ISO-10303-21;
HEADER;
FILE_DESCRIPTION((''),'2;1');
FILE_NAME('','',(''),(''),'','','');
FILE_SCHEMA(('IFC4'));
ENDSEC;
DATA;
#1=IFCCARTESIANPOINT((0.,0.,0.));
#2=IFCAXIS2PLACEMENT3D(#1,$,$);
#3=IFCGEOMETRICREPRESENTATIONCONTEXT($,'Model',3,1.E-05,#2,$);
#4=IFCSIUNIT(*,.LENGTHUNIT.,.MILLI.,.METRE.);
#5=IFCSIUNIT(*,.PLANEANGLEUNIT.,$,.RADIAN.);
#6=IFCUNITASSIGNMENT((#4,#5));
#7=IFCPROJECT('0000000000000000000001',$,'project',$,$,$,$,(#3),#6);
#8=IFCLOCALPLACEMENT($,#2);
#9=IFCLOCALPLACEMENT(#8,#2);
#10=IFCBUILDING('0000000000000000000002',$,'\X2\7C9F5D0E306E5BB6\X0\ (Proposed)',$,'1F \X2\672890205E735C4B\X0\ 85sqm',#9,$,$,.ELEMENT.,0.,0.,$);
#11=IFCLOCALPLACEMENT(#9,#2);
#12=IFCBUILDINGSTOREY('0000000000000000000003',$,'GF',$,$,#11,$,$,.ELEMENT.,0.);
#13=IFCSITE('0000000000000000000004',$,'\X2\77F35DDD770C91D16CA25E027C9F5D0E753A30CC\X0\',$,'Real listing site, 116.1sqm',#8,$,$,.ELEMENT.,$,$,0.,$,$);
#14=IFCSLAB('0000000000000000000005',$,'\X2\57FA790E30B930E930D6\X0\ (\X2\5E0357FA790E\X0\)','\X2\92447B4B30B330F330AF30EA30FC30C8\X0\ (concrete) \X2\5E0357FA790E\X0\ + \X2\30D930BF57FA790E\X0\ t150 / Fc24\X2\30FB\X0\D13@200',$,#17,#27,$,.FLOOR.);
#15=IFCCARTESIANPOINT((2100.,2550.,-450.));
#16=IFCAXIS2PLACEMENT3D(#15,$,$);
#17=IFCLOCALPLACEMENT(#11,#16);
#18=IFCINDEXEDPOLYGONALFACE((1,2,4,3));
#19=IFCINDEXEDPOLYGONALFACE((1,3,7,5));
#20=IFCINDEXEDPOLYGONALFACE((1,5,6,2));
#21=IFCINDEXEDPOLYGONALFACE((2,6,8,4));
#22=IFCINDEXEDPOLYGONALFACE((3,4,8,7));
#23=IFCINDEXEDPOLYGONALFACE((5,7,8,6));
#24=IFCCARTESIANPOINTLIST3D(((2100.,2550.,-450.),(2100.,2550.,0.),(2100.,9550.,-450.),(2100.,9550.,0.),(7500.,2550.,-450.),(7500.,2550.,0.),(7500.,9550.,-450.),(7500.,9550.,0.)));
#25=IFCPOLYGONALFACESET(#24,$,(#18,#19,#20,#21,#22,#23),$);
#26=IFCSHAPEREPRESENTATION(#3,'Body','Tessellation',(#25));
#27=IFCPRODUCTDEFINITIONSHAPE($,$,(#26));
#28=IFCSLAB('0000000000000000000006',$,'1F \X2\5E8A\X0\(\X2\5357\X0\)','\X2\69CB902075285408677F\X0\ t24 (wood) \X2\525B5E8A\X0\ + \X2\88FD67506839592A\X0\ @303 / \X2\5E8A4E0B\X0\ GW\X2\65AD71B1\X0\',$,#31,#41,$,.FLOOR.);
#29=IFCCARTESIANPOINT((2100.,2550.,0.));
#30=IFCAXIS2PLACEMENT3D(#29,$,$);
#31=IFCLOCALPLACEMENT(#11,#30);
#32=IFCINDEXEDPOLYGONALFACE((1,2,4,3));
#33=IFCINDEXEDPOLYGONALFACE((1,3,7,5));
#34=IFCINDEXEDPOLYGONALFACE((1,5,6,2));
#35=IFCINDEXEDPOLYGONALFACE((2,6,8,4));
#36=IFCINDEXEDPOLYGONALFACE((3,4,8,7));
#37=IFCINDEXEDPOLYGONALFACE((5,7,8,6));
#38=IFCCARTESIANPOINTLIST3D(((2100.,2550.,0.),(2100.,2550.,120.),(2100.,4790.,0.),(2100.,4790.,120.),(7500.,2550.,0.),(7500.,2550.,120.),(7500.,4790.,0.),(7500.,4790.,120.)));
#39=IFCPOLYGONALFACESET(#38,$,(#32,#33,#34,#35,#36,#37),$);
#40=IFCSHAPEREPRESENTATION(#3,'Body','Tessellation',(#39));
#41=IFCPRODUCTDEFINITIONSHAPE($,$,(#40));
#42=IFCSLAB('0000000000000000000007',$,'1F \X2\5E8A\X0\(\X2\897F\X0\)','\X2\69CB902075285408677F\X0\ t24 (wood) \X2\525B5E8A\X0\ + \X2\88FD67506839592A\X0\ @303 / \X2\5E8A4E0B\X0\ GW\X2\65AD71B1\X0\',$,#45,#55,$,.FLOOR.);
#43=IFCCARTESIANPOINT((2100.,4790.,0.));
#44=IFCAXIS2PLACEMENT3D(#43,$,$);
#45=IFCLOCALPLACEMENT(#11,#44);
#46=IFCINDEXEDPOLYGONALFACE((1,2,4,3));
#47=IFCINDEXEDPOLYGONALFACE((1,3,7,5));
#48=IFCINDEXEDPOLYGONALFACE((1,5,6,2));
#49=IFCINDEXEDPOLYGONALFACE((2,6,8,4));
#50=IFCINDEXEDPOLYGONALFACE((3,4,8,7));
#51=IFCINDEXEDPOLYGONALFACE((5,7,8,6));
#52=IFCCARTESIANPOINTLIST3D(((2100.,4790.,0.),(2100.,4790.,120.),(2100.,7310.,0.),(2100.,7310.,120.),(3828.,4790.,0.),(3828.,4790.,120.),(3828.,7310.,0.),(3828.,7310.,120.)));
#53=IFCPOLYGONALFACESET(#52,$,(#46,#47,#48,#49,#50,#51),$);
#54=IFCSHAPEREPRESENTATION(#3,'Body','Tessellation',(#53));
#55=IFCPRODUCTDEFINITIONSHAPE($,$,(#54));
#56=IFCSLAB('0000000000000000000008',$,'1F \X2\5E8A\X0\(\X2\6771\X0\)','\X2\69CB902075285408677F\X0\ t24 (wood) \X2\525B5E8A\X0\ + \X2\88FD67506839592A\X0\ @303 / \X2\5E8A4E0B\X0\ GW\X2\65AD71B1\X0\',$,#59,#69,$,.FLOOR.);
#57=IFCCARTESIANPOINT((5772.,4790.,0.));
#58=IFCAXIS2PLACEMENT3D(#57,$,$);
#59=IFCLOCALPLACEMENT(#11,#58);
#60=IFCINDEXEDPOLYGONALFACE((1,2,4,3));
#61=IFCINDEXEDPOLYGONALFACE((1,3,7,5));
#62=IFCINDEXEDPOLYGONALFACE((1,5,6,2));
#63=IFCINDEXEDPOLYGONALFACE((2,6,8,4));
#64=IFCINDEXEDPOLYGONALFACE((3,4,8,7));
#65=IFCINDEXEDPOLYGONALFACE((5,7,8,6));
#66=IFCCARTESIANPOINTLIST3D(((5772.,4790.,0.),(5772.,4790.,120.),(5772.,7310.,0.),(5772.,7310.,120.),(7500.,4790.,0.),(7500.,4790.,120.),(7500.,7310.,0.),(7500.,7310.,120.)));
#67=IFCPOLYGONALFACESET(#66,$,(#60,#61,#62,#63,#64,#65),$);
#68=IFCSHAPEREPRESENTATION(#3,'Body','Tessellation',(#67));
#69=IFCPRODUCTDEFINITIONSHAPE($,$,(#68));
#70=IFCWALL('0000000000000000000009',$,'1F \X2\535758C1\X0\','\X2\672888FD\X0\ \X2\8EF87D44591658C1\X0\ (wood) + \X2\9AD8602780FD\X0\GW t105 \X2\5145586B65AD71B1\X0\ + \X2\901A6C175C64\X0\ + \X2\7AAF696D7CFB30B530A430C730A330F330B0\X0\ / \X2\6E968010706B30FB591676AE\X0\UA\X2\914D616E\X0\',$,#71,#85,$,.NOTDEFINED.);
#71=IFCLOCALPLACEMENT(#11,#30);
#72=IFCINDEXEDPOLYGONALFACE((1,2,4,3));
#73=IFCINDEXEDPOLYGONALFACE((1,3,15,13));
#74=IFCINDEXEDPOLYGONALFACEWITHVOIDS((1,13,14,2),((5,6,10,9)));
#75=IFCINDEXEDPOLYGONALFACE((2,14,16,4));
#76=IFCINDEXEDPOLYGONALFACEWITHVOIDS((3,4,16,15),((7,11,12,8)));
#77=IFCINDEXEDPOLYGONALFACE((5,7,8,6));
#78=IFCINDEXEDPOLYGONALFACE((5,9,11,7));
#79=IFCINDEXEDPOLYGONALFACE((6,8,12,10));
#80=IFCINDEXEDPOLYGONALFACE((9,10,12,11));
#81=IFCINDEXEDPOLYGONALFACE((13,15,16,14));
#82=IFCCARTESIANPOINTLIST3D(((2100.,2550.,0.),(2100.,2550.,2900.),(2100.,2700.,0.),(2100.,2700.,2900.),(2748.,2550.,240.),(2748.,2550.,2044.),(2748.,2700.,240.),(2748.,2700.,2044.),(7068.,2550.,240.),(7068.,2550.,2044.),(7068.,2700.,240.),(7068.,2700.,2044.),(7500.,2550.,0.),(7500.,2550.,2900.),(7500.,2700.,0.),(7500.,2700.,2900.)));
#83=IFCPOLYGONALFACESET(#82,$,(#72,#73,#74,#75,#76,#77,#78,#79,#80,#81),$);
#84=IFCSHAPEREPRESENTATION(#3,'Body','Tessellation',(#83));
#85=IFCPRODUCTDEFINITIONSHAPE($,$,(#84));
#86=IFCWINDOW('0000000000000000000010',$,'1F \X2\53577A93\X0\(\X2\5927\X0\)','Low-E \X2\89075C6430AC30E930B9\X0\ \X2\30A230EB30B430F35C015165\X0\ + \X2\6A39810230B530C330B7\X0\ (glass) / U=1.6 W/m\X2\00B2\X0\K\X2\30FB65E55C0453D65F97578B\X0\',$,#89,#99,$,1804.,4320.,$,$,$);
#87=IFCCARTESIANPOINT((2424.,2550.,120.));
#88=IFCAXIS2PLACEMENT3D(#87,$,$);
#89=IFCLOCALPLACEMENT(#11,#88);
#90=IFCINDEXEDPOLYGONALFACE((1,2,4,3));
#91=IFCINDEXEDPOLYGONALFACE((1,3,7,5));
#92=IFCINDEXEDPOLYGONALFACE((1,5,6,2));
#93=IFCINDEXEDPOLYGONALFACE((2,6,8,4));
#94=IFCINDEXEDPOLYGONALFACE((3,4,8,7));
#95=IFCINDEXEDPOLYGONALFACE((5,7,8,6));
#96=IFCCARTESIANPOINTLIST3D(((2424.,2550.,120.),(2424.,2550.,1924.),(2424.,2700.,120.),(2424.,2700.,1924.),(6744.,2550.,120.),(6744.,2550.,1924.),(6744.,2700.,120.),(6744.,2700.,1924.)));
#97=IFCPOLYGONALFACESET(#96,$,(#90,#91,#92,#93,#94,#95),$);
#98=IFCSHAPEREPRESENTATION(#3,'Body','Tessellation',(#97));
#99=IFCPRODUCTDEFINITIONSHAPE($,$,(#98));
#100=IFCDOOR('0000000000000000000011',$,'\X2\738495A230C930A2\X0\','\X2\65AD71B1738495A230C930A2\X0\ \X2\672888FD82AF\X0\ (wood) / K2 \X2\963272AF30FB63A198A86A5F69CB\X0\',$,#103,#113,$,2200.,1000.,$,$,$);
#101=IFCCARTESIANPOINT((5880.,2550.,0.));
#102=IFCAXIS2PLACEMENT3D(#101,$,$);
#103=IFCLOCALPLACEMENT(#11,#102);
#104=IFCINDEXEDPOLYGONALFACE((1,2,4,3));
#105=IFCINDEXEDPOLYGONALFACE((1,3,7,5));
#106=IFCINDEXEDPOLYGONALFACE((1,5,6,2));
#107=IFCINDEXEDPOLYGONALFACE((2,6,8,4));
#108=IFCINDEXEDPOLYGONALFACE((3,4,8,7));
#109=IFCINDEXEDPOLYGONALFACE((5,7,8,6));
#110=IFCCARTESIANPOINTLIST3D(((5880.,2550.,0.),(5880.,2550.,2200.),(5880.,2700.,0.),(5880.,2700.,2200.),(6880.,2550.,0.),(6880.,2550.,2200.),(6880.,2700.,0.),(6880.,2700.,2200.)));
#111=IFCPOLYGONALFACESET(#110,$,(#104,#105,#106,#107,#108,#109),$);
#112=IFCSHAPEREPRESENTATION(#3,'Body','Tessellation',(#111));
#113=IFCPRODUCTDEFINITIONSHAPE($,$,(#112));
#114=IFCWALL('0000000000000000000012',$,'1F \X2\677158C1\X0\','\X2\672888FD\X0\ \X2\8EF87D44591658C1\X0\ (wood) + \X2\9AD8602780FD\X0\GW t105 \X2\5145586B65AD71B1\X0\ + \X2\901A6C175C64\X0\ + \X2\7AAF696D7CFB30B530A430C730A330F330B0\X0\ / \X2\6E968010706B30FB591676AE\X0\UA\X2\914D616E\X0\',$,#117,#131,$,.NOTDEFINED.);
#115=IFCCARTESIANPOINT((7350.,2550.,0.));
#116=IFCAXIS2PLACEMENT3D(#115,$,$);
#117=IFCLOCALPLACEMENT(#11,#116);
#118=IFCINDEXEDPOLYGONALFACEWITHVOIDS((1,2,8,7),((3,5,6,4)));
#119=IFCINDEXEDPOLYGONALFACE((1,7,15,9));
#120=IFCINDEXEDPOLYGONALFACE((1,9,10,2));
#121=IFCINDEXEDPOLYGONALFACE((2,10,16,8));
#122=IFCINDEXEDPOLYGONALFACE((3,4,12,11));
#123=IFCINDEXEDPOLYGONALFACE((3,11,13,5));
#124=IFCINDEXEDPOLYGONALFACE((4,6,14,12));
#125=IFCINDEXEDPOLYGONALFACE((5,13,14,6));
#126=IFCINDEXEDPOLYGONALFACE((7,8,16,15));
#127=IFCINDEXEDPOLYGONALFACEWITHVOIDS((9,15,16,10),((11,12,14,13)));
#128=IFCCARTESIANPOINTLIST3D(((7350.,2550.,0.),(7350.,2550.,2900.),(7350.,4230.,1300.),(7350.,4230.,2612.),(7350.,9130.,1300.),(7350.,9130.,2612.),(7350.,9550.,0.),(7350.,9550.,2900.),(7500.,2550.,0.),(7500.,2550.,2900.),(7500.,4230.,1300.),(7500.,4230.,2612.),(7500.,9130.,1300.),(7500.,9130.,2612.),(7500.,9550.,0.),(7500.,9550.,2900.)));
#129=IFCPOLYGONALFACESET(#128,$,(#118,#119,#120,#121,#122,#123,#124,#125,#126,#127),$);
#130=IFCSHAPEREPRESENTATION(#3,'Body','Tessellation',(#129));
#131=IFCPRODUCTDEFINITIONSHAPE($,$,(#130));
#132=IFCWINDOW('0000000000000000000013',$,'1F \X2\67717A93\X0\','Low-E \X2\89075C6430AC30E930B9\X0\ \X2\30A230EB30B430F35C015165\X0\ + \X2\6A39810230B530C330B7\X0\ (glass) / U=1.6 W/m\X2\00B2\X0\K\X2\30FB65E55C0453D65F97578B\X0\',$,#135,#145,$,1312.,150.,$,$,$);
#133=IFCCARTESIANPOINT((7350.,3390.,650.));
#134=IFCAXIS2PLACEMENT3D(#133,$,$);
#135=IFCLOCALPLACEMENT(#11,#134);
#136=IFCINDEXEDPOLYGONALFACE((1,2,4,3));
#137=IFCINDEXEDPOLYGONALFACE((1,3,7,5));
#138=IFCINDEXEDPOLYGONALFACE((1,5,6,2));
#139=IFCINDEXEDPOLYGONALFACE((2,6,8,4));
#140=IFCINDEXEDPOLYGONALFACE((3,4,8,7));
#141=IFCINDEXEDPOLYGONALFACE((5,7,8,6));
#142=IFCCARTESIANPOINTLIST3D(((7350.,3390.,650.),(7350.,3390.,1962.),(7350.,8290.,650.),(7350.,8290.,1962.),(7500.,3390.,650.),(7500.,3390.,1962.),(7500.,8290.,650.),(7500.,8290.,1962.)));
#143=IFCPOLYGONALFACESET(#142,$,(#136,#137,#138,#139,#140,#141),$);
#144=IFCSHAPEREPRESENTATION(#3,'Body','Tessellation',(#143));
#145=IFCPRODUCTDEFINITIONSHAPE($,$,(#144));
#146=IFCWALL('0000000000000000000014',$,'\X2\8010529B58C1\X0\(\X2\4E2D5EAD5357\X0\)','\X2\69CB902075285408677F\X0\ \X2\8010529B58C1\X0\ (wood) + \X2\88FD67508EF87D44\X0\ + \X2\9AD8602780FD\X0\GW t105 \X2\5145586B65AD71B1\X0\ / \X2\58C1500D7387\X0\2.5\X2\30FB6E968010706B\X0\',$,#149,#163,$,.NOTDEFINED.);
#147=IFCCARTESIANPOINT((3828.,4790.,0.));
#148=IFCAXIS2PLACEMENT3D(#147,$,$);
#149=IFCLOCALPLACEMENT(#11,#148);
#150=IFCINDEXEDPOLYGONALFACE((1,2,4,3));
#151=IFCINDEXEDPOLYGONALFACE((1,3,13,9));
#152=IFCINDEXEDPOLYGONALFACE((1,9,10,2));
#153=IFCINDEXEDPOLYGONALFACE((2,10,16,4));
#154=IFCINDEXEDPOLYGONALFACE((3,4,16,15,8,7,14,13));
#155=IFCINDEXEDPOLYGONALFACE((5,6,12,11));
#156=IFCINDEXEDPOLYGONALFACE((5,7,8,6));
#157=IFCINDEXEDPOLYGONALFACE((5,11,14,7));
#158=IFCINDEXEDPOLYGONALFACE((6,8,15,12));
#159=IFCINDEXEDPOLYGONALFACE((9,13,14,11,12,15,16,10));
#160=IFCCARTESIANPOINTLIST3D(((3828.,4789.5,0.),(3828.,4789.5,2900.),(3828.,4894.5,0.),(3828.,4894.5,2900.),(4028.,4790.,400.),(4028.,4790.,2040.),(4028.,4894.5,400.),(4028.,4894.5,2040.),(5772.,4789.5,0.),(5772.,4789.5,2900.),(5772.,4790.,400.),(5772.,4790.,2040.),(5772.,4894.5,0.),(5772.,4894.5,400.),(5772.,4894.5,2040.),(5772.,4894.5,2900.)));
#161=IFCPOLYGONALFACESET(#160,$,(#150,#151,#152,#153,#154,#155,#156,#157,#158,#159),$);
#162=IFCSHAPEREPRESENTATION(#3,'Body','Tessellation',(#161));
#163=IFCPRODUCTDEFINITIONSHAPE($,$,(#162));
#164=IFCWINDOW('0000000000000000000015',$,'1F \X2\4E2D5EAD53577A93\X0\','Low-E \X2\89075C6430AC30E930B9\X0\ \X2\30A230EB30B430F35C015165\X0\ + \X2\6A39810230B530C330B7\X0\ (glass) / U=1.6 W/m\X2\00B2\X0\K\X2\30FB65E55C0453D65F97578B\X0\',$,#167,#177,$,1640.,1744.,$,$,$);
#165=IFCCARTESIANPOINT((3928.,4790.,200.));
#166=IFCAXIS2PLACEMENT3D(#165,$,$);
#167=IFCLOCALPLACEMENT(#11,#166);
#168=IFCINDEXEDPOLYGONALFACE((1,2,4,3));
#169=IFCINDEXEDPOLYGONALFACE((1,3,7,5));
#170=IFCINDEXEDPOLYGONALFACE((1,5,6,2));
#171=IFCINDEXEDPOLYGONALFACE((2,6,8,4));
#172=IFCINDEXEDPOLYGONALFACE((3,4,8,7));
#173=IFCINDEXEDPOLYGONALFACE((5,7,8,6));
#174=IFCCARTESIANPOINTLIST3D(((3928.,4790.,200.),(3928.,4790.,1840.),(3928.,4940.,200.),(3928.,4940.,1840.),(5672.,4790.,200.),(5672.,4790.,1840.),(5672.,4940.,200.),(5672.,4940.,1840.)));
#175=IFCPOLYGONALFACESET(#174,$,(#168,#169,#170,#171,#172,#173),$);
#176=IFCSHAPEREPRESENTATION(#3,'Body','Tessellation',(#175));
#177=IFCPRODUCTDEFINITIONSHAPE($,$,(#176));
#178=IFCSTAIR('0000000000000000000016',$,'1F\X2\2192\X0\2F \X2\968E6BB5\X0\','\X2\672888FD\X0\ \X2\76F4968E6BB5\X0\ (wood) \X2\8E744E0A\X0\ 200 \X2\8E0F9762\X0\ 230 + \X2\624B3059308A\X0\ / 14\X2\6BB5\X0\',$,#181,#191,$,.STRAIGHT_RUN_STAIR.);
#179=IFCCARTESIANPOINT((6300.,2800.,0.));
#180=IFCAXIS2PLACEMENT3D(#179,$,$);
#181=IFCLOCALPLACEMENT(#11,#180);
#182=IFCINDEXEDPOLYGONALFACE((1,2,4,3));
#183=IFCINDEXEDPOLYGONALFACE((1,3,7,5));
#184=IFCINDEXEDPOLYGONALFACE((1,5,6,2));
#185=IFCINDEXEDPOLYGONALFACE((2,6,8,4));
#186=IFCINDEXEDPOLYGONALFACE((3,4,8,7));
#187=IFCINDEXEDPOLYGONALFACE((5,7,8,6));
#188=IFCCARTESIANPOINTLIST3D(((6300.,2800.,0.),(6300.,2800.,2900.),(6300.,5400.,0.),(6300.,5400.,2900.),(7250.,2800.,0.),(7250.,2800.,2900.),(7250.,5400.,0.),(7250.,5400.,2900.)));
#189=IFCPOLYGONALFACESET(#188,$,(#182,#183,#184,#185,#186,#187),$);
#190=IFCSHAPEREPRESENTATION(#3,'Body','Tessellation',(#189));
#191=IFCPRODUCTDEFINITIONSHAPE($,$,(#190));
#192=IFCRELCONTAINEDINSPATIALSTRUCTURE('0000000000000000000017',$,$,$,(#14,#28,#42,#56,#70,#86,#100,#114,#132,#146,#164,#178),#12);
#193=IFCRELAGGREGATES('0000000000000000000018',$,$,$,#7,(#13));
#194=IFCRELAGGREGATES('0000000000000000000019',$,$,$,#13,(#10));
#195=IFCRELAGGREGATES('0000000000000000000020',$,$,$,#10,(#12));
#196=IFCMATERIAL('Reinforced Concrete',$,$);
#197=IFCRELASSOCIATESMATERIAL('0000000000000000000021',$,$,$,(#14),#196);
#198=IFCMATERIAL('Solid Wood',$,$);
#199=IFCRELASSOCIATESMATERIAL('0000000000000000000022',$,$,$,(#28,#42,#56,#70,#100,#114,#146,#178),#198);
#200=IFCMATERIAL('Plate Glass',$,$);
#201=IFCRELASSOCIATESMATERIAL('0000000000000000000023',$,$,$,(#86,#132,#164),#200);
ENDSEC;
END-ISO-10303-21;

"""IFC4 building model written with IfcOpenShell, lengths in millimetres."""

from ifc_helpers import new_model, si_unit, frame, frame_2d, origin, place, context, project, spatial, rectangle, extrude, material, element, fill, save


model = new_model("IFC4")

# Units and contexts
model_context = context("Model", 3, precision=1e-05, world=origin())
ifc_project = project(units=[si_unit("LENGTHUNIT", "METRE", prefix="MILLI"), si_unit("PLANEANGLEUNIT", "RADIAN")], contexts=[model_context])

# Site, building, storey
site_placement = place(None, origin())
site = spatial("IfcSite", under=ifc_project, at=site_placement, Name="石川県金沢市粟崎町ヌ", ObjectType="Real listing site, 116.1sqm", CompositionType="ELEMENT", RefElevation=0.0)
building_placement = place(site_placement, origin())
building = spatial("IfcBuilding", under=site, at=building_placement, Name="粟崎の家 (Proposed)", ObjectType="1F 木造平屋 85sqm", CompositionType="ELEMENT", ElevationOfRefHeight=0.0, ElevationOfTerrain=0.0)
storey_placement = place(building_placement, origin())
storey = spatial("IfcBuildingStorey", under=building, at=storey_placement, Name="GF", CompositionType="ELEMENT", Elevation=0.0)

# Slabs
ifc_material_1 = material(Name="Reinforced Concrete")
slab_1_placement = place(storey_placement, frame((2100.0, 2550.0, -450.0)))
element("IfcSlab", 1, at=slab_1_placement, inside=storey, material=ifc_material_1, Name="基礎スラブ (布基礎)", Description="鉄筋コンクリート (concrete) 布基礎 + ベタ基礎 t150 / Fc24・D13@200", PredefinedType="FLOOR", context=model_context, shape_type="SweptSolid", body=[
    extrude(rectangle(XDim=5400.0, YDim=7000.0, at=frame_2d((2700.0, 3500.0))), frame((2100.0, 2550.0, -450.0)), (0.0, 0.0, 1.0), 450.0),
])
ifc_material_2 = material(Name="Solid Wood")
slab_2_placement = place(storey_placement, frame((2100.0, 2550.0, 0.0)))
element("IfcSlab", 2, at=slab_2_placement, inside=storey, material=ifc_material_2, Name="1F 床(南)", Description="構造用合板 t24 (wood) 剛床 + 製材根太 @303 / 床下 GW断熱", PredefinedType="FLOOR", context=model_context, shape_type="SweptSolid", body=[
    extrude(rectangle(XDim=5400.0, YDim=2240.0, at=frame_2d((2700.0, 1120.0))), frame((2100.0, 2550.0, 0.0)), (0.0, 0.0, 1.0), 120.0),
])
slab_3_placement = place(storey_placement, frame((2100.0, 4790.0, 0.0)))
element("IfcSlab", 3, at=slab_3_placement, inside=storey, material=ifc_material_2, Name="1F 床(西)", Description="構造用合板 t24 (wood) 剛床 + 製材根太 @303 / 床下 GW断熱", PredefinedType="FLOOR", context=model_context, shape_type="SweptSolid", body=[
    extrude(rectangle(XDim=1728.0, YDim=2520.0, at=frame_2d((864.0, 1260.0))), frame((2100.0, 4790.0, 0.0)), (0.0, 0.0, 1.0), 120.0),
])
slab_4_placement = place(storey_placement, frame((5772.0, 4790.0, 0.0)))
element("IfcSlab", 4, at=slab_4_placement, inside=storey, material=ifc_material_2, Name="1F 床(東)", Description="構造用合板 t24 (wood) 剛床 + 製材根太 @303 / 床下 GW断熱", PredefinedType="FLOOR", context=model_context, shape_type="SweptSolid", body=[
    extrude(rectangle(XDim=1728.0, YDim=2520.0, at=frame_2d((864.0, 1260.0))), frame((5772.0, 4790.0, 0.0)), (0.0, 0.0, 1.0), 120.0),
])

# Wall, openings, window, door
wall_1_placement = place(storey_placement, frame((2100.0, 2550.0, 0.0)))
wall_1 = element("IfcWall", 5, at=wall_1_placement, inside=storey, material=ifc_material_2, Name="1F 南壁", Description="木製 軸組外壁 (wood) + 高性能GW t105 充填断熱 + 通気層 + 窯業系サイディング / 準耐火・外皮UA配慮", PredefinedType="NOTDEFINED", context=model_context, shape_type="SweptSolid", body=[
    extrude(rectangle(XDim=5400.0, YDim=150.0, at=frame_2d((2700.0, 75.0))), frame((2100.0, 2550.0, 0.0)), (0.0, 0.0, 1.0), 2900.0),
])
opening_1_placement = place(storey_placement, frame((2424.0, 2550.0, 120.0)))
opening_1 = element("IfcOpeningElement", 6, at=opening_1_placement, cuts=wall_1, PredefinedType="NOTDEFINED", context=model_context, shape_type="SweptSolid", body=[
    extrude(rectangle(XDim=4320.0, YDim=150.0, at=frame_2d((2160.0, 75.0))), frame((2424.0, 2550.0, 120.0)), (0.0, 0.0, 1.0), 1804.0),
])
opening_2_placement = place(storey_placement, frame((5880.0, 2550.0, 0.0)))
opening_2 = element("IfcOpeningElement", 7, at=opening_2_placement, cuts=wall_1, PredefinedType="NOTDEFINED", context=model_context, shape_type="SweptSolid", body=[
    extrude(rectangle(XDim=1000.0, YDim=150.0, at=frame_2d((500.0, 75.0))), frame((5880.0, 2550.0, 0.0)), (0.0, 0.0, 1.0), 2200.0),
])
ifc_material_3 = material(Name="Plate Glass")
window_1_placement = place(storey_placement, frame((2424.0, 2550.0, 120.0)))
window_1 = element("IfcWindow", 8, at=window_1_placement, inside=storey, material=ifc_material_3, Name="1F 南窓(大)", Description="Low-E 複層ガラス アルゴン封入 + 樹脂サッシ (glass) / U=1.6 W/m²K・日射取得型", OverallHeight=1804.0, OverallWidth=4320.0, context=model_context, shape_type="SweptSolid", body=[
    extrude(rectangle(XDim=4320.0, YDim=150.0, at=frame_2d((2160.0, 75.0))), frame((2424.0, 2550.0, 120.0)), (0.0, 0.0, 1.0), 1804.0),
])
fill(opening_1, window_1)
door_placement = place(storey_placement, frame((5880.0, 2550.0, 0.0)))
door = element("IfcDoor", 9, at=door_placement, inside=storey, material=ifc_material_2, Name="玄関ドア", Description="断熱玄関ドア 木製芯 (wood) / K2 防犯・採風機構", OverallHeight=2200.0, OverallWidth=1000.0, context=model_context, shape_type="SweptSolid", body=[
    extrude(rectangle(XDim=1000.0, YDim=150.0, at=frame_2d((500.0, 75.0))), frame((5880.0, 2550.0, 0.0)), (0.0, 0.0, 1.0), 2200.0),
])
fill(opening_2, door)

# Walls, openings, windows
wall_2_placement = place(storey_placement, frame((7350.0, 2550.0, 0.0)))
wall_2 = element("IfcWall", 10, at=wall_2_placement, inside=storey, material=ifc_material_2, Name="1F 東壁", Description="木製 軸組外壁 (wood) + 高性能GW t105 充填断熱 + 通気層 + 窯業系サイディング / 準耐火・外皮UA配慮", PredefinedType="NOTDEFINED", context=model_context, shape_type="SweptSolid", body=[
    extrude(rectangle(XDim=150.0, YDim=7000.0, at=frame_2d((75.0, 3500.0))), frame((7350.0, 2550.0, 0.0)), (0.0, 0.0, 1.0), 2900.0),
])
opening_3_placement = place(storey_placement, frame((7350.0, 3390.0, 650.0)))
opening_3 = element("IfcOpeningElement", 11, at=opening_3_placement, cuts=wall_2, PredefinedType="NOTDEFINED", context=model_context, shape_type="SweptSolid", body=[
    extrude(rectangle(XDim=150.0, YDim=4900.0, at=frame_2d((75.0, 2450.0))), frame((7350.0, 3390.0, 650.0)), (0.0, 0.0, 1.0), 1312.0),
])
window_2_placement = place(storey_placement, frame((7350.0, 3390.0, 650.0)))
window_2 = element("IfcWindow", 12, at=window_2_placement, inside=storey, material=ifc_material_3, Name="1F 東窓", Description="Low-E 複層ガラス アルゴン封入 + 樹脂サッシ (glass) / U=1.6 W/m²K・日射取得型", OverallHeight=1312.0, OverallWidth=150.0, context=model_context, shape_type="SweptSolid", body=[
    extrude(rectangle(XDim=150.0, YDim=4900.0, at=frame_2d((75.0, 2450.0))), frame((7350.0, 3390.0, 650.0)), (0.0, 0.0, 1.0), 1312.0),
])
fill(opening_3, window_2)
wall_3_placement = place(storey_placement, frame((3828.0, 4790.0, 0.0)))
wall_3 = element("IfcWall", 13, at=wall_3_placement, inside=storey, material=ifc_material_2, Name="耐力壁(中庭南)", Description="構造用合板 耐力壁 (wood) + 製材軸組 + 高性能GW t105 充填断熱 / 壁倍率2.5・準耐火", PredefinedType="NOTDEFINED", context=model_context, shape_type="SweptSolid", body=[
    extrude(rectangle(XDim=1944.0, YDim=105.0, at=frame_2d((972.0, 52.0))), frame((3828.0, 4790.0, 0.0)), (0.0, 0.0, 1.0), 2900.0),
])
opening_4_placement = place(storey_placement, frame((3928.0, 4790.0, 200.0)))
opening_4 = element("IfcOpeningElement", 14, at=opening_4_placement, cuts=wall_3, PredefinedType="NOTDEFINED", context=model_context, shape_type="SweptSolid", body=[
    extrude(rectangle(XDim=1744.0, YDim=150.0, at=frame_2d((872.0, 75.0))), frame((3928.0, 4790.0, 200.0)), (0.0, 0.0, 1.0), 1640.0),
])
window_3_placement = place(storey_placement, frame((3928.0, 4790.0, 200.0)))
window_3 = element("IfcWindow", 15, at=window_3_placement, inside=storey, material=ifc_material_3, Name="1F 中庭南窓", Description="Low-E 複層ガラス アルゴン封入 + 樹脂サッシ (glass) / U=1.6 W/m²K・日射取得型", OverallHeight=1640.0, OverallWidth=1744.0, context=model_context, shape_type="SweptSolid", body=[
    extrude(rectangle(XDim=1744.0, YDim=150.0, at=frame_2d((872.0, 75.0))), frame((3928.0, 4790.0, 200.0)), (0.0, 0.0, 1.0), 1640.0),
])
fill(opening_4, window_3)

# Stair
stair_placement = place(storey_placement, frame((6300.0, 2800.0, 0.0)))
element("IfcStair", 16, at=stair_placement, inside=storey, material=ifc_material_2, Name="1F→2F 階段", Description="木製 直階段 (wood) 蹴上 200 踏面 230 + 手すり / 14段", PredefinedType="STRAIGHT_RUN_STAIR", context=model_context, shape_type="SweptSolid", body=[
    extrude(rectangle(XDim=950.0, YDim=2600.0, at=frame_2d((475.0, 1300.0))), frame((6300.0, 2800.0, 0.0)), (0.0, 0.0, 1.0), 2900.0),
])

save(model, "model.ifc")
